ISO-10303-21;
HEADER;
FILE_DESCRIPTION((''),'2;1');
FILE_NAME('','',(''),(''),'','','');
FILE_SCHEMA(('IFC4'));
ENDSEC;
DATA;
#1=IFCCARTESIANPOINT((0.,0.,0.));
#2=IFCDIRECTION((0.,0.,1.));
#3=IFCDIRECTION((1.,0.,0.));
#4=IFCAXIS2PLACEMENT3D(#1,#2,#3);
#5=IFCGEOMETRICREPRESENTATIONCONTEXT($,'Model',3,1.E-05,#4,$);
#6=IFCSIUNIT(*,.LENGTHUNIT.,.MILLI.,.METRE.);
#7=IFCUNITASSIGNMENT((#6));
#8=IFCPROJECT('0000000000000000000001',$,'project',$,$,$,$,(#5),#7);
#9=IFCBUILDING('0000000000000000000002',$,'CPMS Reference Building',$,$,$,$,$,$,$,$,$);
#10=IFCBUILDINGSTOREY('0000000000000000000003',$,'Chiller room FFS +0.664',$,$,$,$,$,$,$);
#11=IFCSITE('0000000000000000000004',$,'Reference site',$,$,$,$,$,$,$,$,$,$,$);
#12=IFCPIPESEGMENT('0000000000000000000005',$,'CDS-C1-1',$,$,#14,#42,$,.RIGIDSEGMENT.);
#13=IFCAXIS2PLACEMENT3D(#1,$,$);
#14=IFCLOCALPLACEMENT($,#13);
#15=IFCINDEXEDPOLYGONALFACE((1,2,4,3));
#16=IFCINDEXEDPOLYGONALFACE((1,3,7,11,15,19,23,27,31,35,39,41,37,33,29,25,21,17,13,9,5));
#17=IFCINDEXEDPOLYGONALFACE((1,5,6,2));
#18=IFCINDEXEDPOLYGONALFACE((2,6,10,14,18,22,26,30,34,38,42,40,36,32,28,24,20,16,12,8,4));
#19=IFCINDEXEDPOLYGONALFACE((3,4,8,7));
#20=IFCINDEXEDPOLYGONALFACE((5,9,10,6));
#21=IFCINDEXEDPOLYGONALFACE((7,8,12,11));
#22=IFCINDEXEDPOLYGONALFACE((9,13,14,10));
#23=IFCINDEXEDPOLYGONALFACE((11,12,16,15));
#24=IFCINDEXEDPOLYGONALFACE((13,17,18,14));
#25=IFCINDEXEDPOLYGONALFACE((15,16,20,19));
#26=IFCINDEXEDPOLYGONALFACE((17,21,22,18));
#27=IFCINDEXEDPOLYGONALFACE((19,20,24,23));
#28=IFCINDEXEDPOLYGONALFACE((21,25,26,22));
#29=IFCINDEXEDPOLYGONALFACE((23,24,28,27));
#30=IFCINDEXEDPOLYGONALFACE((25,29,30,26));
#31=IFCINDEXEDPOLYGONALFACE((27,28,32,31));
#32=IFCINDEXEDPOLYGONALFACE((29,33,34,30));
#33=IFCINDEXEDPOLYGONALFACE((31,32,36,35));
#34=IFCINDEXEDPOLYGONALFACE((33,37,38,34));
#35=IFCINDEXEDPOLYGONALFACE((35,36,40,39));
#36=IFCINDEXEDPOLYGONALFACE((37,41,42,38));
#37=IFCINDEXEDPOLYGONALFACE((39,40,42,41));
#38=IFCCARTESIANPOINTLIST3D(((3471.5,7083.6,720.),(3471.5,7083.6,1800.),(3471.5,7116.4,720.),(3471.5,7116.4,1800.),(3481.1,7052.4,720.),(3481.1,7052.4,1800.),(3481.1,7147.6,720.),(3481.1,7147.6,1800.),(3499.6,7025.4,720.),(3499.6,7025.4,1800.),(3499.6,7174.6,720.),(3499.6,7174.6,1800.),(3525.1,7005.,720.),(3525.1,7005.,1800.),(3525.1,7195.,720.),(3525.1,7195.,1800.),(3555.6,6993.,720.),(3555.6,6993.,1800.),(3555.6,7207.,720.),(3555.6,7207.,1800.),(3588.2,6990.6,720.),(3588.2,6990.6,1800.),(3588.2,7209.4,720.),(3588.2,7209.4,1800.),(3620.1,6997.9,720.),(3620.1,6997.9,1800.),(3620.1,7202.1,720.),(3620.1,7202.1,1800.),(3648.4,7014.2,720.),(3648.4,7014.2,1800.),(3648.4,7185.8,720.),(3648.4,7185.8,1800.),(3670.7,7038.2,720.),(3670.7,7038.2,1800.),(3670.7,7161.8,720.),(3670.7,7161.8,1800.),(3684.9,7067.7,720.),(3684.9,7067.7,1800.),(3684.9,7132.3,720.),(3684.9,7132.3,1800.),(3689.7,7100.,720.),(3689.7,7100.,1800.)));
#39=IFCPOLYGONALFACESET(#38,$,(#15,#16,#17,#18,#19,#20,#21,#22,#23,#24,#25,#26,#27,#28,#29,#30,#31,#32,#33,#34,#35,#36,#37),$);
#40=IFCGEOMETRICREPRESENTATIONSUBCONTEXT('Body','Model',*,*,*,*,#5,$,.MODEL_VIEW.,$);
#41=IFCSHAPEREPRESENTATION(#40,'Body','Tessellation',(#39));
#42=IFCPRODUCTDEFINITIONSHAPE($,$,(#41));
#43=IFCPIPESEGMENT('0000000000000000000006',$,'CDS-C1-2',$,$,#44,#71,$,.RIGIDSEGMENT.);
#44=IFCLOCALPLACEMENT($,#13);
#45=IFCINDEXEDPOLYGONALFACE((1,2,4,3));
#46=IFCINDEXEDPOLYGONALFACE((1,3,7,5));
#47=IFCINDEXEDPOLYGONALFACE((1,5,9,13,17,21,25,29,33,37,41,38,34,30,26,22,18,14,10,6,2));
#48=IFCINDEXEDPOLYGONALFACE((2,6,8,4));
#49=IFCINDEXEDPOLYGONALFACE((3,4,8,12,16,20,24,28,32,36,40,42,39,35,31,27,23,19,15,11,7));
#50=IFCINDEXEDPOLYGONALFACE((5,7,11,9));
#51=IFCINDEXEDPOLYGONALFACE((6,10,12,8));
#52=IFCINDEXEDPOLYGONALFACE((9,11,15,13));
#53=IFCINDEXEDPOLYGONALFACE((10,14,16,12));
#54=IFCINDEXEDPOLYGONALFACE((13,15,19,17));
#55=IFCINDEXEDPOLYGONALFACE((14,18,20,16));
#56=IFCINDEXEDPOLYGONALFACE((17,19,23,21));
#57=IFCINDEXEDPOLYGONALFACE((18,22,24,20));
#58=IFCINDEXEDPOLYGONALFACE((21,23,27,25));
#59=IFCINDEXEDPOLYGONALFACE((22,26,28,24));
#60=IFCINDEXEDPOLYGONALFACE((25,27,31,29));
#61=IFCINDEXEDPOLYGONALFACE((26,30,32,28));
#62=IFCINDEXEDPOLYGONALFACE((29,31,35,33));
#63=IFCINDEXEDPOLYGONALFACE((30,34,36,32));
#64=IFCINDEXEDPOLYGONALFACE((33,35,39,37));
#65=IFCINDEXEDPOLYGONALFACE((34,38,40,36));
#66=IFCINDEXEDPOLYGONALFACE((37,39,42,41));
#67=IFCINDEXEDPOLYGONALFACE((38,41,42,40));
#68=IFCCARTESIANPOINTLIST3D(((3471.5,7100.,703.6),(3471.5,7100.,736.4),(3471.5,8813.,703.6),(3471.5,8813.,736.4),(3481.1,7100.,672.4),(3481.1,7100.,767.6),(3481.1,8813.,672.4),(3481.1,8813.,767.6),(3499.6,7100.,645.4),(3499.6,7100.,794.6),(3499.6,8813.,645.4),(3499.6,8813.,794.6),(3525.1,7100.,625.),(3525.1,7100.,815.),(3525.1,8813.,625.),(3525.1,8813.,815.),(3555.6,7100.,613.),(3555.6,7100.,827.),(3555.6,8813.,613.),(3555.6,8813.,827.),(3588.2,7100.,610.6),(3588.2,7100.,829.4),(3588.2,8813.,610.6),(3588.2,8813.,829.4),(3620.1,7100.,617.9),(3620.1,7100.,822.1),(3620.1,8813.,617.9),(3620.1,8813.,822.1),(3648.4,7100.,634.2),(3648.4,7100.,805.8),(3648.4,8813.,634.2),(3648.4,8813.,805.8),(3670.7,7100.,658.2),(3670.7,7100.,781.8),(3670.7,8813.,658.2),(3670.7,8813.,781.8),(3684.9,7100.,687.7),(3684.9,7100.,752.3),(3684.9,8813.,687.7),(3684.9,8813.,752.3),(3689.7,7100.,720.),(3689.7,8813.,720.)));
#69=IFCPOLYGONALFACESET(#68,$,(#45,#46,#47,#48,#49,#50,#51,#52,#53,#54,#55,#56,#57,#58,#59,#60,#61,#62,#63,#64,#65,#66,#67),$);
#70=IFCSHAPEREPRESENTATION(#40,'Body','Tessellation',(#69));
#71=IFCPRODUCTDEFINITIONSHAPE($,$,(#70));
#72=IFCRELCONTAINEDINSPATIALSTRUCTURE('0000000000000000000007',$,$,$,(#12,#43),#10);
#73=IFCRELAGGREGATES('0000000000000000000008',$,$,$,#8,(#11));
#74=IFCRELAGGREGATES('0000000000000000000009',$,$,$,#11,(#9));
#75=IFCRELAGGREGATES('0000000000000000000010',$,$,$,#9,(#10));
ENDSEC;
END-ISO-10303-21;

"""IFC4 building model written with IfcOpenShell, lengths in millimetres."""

from ifc_helpers import new_model, si_unit, frame, origin_with_axes, origin_2d, place, context, subcontext, project, spatial, circle_curve, outline, extrude, element, save


model = new_model("IFC4")

# Units and contexts
model_context = context("Model", 3, precision=1e-05, world=origin_with_axes())
body_context = subcontext(model_context, "Body", "Model", "MODEL_VIEW")
ifc_project = project(units=[si_unit("LENGTHUNIT", "METRE", prefix="MILLI")], contexts=[model_context])

# Site, building, storey
site = spatial("IfcSite", under=ifc_project, Name="Reference site")
building = spatial("IfcBuilding", under=site, Name="CPMS Reference Building")
storey = spatial("IfcBuildingStorey", under=building, Name="Chiller room FFS +0.664")

# Pipe segments
pipe_segment_1_placement = place(None, origin_with_axes())
element("IfcPipeSegment", 1, at=pipe_segment_1_placement, inside=storey, Name="CDS-C1-1", PredefinedType="RIGIDSEGMENT", context=body_context, shape_type="SweptSolid", body=[
    extrude(outline(circle_curve(origin_2d(), 109.7)), frame((3580.0, 7100.0, 1800.0), z_axis=(0.0, 0.0, -1.0), x_axis=(1.0, 0.0, 0.0)), (0.0, 0.0, 1.0), 1080.0),
])
pipe_segment_2_placement = place(None, origin_with_axes())
element("IfcPipeSegment", 2, at=pipe_segment_2_placement, inside=storey, Name="CDS-C1-2", PredefinedType="RIGIDSEGMENT", context=body_context, shape_type="SweptSolid", body=[
    extrude(outline(circle_curve(origin_2d(), 109.7)), frame((3580.0, 7100.0, 720.0), z_axis=(0.0, 1.0, 0.0), x_axis=(1.0, 0.0, 0.0)), (0.0, 0.0, 1.0), 1713.0),
])

save(model, "model.ifc")
